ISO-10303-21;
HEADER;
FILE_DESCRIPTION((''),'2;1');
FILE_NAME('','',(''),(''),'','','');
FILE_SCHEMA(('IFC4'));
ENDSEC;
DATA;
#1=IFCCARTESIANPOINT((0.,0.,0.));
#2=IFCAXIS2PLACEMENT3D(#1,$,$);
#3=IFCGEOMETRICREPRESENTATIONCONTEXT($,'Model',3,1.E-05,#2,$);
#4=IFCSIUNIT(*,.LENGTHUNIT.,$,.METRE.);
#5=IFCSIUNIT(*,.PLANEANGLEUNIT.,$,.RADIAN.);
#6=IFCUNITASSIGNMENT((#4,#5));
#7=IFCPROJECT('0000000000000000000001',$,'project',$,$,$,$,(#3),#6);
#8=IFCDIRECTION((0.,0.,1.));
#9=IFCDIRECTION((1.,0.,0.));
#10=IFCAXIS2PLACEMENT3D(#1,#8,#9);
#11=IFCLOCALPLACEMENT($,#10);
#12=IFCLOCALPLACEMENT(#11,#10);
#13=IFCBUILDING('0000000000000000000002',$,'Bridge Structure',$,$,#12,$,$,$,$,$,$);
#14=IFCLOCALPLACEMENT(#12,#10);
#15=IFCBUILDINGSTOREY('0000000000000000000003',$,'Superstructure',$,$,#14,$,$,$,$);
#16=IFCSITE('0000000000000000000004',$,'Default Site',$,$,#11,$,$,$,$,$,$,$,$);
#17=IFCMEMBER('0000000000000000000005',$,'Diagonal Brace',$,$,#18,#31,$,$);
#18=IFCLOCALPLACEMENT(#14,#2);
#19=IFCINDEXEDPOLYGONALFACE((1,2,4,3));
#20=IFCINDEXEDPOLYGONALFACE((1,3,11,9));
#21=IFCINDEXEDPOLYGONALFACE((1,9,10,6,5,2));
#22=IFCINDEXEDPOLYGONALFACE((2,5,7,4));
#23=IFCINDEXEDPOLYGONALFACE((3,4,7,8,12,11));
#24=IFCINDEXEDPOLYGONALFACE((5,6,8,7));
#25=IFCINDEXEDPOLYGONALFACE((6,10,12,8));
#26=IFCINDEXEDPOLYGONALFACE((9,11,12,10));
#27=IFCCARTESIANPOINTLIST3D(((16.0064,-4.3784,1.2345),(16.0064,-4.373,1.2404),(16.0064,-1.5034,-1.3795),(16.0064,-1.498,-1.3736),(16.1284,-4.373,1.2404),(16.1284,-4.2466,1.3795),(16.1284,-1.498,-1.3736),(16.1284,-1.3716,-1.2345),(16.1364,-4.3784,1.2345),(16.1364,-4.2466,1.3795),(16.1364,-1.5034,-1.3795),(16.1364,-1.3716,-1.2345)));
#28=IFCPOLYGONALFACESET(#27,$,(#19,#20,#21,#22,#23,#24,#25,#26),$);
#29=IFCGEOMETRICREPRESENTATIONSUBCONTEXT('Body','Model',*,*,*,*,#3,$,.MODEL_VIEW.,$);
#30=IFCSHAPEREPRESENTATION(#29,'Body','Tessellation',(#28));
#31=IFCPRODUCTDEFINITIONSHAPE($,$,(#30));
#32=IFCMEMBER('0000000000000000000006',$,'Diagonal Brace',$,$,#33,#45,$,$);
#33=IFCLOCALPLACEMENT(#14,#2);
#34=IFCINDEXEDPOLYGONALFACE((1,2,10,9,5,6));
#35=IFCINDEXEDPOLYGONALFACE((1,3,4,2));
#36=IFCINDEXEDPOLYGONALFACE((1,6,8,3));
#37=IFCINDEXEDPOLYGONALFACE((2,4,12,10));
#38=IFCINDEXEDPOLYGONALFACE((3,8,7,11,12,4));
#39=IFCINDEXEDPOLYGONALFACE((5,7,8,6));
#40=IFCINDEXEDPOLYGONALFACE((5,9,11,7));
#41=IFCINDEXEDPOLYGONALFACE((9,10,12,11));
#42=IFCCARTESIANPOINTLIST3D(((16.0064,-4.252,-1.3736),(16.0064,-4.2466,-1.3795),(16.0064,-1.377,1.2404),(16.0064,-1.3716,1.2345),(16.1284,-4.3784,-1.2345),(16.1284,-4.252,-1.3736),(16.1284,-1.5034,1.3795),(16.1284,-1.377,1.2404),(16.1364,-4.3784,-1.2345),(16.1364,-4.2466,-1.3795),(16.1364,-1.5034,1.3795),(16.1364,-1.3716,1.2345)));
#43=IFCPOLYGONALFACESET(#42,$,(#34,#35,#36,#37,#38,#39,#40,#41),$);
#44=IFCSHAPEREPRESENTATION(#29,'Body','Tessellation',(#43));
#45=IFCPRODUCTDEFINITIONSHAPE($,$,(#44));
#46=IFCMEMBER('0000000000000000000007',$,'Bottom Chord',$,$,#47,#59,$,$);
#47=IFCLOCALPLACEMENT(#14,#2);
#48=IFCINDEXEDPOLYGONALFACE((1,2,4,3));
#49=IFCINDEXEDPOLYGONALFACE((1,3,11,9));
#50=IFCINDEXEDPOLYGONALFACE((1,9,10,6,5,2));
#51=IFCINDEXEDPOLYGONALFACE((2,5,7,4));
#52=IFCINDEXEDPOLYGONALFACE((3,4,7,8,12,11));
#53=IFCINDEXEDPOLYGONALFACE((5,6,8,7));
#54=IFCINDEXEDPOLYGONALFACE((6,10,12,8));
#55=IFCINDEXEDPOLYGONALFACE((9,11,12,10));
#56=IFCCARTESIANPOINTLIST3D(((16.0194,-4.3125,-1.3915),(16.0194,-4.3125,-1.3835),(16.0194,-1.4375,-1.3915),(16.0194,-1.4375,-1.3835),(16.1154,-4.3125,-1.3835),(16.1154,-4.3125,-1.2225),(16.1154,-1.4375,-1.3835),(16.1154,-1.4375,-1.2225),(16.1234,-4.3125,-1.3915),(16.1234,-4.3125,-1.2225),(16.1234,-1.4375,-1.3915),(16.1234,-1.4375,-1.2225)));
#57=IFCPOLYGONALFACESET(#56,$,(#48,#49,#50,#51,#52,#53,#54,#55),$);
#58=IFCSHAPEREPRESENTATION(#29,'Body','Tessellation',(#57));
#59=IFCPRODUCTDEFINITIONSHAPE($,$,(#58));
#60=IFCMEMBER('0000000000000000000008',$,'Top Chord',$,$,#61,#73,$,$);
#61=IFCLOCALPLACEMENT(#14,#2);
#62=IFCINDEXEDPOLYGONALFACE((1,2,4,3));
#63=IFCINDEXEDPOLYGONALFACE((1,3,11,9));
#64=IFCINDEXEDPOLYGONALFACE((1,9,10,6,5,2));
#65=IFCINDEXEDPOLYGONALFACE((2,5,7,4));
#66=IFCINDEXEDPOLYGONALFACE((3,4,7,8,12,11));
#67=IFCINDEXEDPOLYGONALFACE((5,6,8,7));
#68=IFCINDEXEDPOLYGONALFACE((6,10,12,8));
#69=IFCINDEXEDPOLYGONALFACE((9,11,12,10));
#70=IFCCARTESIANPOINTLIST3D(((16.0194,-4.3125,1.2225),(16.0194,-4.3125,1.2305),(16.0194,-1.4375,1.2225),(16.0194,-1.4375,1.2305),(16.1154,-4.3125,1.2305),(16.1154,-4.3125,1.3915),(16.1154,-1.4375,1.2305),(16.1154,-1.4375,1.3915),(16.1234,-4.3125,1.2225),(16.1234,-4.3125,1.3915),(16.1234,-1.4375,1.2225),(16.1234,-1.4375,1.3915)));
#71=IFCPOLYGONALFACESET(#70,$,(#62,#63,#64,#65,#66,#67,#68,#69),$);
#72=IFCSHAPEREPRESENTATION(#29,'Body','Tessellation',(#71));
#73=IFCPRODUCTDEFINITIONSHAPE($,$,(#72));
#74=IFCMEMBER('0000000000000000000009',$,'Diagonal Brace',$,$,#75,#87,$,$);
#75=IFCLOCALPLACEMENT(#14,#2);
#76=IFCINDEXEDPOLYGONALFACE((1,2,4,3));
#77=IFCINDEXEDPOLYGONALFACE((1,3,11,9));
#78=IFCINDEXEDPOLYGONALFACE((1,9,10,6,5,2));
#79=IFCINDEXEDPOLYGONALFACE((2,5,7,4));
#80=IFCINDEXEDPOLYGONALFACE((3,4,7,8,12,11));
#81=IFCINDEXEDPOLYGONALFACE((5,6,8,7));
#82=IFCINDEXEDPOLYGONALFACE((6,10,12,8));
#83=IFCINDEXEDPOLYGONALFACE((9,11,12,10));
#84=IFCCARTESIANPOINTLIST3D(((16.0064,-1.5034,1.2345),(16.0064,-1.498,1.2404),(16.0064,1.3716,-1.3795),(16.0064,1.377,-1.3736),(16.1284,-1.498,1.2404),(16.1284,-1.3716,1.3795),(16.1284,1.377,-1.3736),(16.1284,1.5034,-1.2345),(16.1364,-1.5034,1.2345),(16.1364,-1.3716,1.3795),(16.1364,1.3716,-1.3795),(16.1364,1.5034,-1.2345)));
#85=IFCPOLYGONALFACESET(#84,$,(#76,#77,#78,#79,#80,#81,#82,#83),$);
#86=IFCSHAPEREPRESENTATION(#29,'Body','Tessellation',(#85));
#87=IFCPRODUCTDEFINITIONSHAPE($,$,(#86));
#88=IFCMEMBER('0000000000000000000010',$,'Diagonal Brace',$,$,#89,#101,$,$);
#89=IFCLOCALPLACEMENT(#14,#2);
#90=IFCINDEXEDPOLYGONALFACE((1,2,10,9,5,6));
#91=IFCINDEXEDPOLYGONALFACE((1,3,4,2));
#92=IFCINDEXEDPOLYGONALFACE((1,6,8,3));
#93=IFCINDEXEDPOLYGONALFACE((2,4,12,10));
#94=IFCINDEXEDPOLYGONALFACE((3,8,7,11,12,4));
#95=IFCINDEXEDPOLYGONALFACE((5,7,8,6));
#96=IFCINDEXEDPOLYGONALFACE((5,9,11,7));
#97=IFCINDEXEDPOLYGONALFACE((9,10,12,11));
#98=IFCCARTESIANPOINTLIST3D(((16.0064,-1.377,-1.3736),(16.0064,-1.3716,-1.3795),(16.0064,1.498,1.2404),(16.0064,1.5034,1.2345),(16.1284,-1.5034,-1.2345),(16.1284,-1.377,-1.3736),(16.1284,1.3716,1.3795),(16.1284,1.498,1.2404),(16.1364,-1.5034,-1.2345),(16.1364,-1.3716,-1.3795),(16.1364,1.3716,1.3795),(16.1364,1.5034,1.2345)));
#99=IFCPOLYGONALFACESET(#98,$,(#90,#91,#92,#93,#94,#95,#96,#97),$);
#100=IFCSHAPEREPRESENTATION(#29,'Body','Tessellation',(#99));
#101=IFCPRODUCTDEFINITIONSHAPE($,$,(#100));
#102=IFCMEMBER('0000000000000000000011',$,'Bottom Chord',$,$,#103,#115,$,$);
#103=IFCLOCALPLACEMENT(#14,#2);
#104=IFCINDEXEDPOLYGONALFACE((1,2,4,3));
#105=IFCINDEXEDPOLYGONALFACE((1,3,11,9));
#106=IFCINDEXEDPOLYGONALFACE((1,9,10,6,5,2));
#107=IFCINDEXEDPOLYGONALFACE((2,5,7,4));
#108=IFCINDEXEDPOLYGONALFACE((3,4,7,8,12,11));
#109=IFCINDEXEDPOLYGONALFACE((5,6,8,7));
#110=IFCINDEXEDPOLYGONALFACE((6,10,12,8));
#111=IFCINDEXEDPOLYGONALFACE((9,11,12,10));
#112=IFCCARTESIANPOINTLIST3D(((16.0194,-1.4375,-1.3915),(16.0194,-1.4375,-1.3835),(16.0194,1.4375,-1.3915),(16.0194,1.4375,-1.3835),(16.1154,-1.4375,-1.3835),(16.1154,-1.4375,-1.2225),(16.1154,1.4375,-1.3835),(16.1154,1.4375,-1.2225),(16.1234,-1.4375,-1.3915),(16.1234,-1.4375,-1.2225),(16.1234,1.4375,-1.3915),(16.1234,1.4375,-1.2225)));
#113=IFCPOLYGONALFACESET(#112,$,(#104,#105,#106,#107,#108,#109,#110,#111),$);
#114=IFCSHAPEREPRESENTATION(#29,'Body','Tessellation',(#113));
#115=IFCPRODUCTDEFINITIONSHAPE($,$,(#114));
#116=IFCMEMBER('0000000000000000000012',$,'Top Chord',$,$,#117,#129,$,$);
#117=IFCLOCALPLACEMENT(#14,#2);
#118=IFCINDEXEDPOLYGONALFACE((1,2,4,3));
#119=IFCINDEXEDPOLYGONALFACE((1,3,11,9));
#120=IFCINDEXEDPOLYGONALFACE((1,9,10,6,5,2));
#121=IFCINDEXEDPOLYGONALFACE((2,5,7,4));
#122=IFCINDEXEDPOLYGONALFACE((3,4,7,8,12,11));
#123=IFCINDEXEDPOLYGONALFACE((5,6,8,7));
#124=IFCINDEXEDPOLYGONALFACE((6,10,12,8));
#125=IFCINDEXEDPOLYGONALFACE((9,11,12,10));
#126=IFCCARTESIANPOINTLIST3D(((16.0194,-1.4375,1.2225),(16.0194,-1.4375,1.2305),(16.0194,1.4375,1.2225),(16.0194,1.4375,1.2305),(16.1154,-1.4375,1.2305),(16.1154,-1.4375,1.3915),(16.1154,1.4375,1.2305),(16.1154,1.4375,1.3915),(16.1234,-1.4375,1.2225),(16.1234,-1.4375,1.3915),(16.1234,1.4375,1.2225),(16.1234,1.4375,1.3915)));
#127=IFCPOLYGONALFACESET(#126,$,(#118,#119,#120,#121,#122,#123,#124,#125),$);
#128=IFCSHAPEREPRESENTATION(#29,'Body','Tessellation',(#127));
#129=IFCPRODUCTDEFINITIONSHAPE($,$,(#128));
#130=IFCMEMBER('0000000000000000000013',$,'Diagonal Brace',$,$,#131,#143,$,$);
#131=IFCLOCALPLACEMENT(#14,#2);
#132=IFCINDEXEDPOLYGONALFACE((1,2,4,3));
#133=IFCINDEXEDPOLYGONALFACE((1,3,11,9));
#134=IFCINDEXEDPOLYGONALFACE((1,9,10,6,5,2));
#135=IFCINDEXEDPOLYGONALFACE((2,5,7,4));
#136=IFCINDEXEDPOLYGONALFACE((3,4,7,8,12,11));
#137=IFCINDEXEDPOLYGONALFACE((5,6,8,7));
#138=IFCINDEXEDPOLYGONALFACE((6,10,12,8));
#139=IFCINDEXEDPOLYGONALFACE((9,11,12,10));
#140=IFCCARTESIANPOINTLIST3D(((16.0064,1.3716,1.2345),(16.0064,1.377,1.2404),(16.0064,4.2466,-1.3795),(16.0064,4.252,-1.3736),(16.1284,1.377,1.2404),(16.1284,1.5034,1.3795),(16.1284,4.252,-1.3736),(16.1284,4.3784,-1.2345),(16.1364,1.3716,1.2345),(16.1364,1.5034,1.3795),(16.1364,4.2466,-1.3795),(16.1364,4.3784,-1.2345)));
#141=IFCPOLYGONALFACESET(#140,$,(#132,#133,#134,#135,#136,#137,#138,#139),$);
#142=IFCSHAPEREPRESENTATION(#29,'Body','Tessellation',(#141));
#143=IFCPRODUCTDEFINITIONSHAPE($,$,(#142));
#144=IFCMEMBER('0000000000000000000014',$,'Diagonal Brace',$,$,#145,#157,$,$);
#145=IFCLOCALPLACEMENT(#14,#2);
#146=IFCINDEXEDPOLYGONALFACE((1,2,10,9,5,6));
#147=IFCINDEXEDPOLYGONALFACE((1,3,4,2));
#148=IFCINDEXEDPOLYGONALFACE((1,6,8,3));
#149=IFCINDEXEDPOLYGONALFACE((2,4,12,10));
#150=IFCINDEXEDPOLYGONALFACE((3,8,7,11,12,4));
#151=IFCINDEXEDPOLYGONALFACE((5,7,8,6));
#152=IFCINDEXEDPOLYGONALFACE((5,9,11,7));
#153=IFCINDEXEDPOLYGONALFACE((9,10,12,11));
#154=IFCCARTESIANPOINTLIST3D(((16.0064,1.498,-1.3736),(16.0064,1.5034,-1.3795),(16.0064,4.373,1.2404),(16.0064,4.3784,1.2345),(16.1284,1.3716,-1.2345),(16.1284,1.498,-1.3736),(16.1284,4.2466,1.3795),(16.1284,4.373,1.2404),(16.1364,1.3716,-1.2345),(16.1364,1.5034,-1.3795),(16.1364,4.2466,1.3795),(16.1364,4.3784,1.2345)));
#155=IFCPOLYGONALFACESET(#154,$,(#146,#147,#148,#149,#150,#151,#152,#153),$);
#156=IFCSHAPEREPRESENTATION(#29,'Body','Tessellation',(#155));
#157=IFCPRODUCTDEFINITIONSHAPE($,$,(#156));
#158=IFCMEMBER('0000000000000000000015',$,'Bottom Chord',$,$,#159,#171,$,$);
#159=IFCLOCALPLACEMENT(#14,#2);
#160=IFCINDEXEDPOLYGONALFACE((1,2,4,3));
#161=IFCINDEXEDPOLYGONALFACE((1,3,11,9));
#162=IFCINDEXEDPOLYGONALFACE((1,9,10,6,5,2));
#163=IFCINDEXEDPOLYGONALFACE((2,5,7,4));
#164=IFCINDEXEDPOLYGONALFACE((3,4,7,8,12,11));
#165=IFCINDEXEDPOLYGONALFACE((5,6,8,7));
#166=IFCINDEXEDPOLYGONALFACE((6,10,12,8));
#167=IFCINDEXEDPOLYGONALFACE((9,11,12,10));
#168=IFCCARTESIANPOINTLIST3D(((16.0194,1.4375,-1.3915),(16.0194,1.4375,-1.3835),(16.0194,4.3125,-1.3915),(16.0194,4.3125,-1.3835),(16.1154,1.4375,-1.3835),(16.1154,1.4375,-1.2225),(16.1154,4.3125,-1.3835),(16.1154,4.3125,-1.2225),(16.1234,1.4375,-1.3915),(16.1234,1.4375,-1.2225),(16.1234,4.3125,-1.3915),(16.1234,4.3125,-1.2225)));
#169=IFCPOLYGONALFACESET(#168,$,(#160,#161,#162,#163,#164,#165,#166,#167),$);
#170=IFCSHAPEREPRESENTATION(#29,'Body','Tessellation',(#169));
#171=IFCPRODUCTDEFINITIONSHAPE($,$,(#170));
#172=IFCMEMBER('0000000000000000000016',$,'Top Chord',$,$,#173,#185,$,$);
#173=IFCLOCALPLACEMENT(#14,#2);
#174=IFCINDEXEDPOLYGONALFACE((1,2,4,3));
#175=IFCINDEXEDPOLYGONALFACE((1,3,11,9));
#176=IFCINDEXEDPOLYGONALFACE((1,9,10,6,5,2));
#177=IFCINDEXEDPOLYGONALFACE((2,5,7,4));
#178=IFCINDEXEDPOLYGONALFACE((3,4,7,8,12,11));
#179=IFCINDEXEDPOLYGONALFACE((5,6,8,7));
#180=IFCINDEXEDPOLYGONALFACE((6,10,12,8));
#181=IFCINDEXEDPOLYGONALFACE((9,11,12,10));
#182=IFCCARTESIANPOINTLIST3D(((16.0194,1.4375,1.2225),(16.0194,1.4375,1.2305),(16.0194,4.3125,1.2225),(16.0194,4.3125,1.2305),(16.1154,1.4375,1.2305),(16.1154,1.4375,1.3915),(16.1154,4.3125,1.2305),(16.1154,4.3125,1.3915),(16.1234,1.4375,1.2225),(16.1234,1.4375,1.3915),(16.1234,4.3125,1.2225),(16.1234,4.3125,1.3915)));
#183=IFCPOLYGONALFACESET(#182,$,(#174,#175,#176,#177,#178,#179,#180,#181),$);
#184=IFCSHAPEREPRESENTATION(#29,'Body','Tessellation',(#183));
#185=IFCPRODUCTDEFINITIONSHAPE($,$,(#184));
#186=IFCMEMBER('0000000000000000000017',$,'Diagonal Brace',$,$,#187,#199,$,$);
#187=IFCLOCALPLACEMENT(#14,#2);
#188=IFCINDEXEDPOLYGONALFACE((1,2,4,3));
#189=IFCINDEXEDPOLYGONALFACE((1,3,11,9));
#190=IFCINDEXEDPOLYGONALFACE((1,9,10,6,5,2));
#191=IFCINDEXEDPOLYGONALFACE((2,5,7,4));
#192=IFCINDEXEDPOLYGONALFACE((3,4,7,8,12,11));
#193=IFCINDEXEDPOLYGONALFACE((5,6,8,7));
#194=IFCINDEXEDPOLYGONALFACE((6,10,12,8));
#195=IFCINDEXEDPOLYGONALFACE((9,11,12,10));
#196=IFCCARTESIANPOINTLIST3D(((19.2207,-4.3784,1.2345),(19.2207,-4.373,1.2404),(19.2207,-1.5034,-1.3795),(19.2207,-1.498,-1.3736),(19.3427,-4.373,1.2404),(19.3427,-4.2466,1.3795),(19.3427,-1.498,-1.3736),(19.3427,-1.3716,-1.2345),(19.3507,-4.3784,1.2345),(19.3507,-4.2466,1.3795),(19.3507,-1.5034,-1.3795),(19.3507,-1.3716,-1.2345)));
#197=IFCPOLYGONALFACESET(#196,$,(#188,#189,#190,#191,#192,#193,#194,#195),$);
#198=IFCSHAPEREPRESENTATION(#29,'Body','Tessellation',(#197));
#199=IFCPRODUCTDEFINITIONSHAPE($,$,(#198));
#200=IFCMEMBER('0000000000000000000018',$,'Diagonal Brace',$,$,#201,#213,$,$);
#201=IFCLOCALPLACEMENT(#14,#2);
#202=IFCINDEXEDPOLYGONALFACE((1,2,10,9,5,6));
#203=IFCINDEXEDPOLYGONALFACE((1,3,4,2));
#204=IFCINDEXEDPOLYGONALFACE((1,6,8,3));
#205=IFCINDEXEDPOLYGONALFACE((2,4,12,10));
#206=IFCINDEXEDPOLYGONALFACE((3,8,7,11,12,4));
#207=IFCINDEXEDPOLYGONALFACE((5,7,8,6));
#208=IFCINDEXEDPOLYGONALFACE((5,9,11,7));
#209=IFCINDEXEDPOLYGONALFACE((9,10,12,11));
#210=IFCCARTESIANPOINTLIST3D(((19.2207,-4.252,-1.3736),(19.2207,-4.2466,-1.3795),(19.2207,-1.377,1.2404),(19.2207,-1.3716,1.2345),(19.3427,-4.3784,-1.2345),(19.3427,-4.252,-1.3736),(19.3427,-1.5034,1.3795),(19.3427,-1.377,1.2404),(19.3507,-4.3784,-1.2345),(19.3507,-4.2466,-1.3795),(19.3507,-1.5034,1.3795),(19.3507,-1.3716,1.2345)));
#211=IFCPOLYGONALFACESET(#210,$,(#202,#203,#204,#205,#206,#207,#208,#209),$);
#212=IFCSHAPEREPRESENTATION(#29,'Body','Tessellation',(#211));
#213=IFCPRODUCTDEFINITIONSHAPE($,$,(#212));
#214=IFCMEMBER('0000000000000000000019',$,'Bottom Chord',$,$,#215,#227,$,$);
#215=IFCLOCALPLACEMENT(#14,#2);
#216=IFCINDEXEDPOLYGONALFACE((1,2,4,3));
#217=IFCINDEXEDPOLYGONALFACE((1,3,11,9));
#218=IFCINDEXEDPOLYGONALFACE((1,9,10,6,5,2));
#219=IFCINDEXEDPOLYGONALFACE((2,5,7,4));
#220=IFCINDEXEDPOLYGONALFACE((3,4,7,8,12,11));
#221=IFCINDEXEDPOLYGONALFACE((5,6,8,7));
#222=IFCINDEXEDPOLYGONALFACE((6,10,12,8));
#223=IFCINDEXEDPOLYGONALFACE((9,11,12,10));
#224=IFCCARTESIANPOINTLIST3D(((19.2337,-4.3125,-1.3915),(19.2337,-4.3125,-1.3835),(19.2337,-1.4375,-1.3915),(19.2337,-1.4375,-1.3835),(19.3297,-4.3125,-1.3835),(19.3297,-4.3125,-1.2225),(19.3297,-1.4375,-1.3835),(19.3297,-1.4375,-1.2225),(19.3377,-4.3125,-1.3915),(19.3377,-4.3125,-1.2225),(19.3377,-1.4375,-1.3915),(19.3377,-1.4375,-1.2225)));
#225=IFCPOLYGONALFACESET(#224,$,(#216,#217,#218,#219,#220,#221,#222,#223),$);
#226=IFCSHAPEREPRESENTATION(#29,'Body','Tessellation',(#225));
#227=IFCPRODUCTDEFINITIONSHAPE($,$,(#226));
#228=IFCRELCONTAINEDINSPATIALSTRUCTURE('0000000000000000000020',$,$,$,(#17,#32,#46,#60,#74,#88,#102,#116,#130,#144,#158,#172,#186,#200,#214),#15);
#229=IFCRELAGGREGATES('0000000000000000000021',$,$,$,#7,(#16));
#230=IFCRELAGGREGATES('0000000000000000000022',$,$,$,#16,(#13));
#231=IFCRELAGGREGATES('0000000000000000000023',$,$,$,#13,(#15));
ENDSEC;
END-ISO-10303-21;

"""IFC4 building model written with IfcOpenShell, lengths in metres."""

from ifc_helpers import new_model, si_unit, frame, origin, origin_with_axes, origin_2d_with_axis, place, context, subcontext, project, spatial, l_section, extrude, element, save


model = new_model("IFC4")

# Units and contexts
model_context = context("Model", 3, precision=1e-05, world=origin())
body_context = subcontext(model_context, "Body", "Model", "MODEL_VIEW")
ifc_project = project(units=[si_unit("LENGTHUNIT", "METRE"), si_unit("PLANEANGLEUNIT", "RADIAN")], contexts=[model_context])

# Site, building, storey
site_placement = place(None, origin_with_axes())
site = spatial("IfcSite", under=ifc_project, at=site_placement, Name="Default Site")
building_placement = place(site_placement, origin_with_axes())
building = spatial("IfcBuilding", under=site, at=building_placement, Name="Bridge Structure")
storey_placement = place(building_placement, origin_with_axes())
storey = spatial("IfcBuildingStorey", under=building, at=storey_placement, Name="Superstructure")

# Members
for number, where, z_axis, x_axis, name in (
    (1, (16.0714, -4.3125, 1.307), (0.0, 0.739893, -0.672724), (-1.0, 0.0, 0.0), "Diagonal Brace"),
    (2, (16.0714, -4.3125, -1.307), (0.0, 0.739893, 0.672724), (-1.0, 0.0, 0.0), "Diagonal Brace"),
):
    element("IfcMember", number, at=place(storey_placement, frame(where, z_axis=z_axis, x_axis=x_axis)), inside=storey, Name=name, context=body_context, shape_type="SweptSolid", body=[
        extrude(l_section(Depth=0.196, Width=0.13, Thickness=0.008, at=origin_2d_with_axis()), origin_with_axes(), (0.0, 0.0, 1.0), 3.8857),
    ])
for number, where, z_axis, x_axis, name in (
    (3, (16.0714, -4.3125, -1.307), (0.0, 1.0, 0.0), (-1.0, 0.0, 0.0), "Bottom Chord"),
    (4, (16.0714, -4.3125, 1.307), (0.0, 1.0, 0.0), (-1.0, 0.0, 0.0), "Top Chord"),
):
    element("IfcMember", number, at=place(storey_placement, frame(where, z_axis=z_axis, x_axis=x_axis)), inside=storey, Name=name, context=body_context, shape_type="SweptSolid", body=[
        extrude(l_section(Depth=0.169, Width=0.104, Thickness=0.008, at=origin_2d_with_axis()), origin_with_axes(), (0.0, 0.0, 1.0), 2.875),
    ])
for number, where, z_axis, x_axis, name in (
    (5, (16.0714, -1.4375, 1.307), (0.0, 0.739893, -0.672724), (-1.0, 0.0, 0.0), "Diagonal Brace"),
    (6, (16.0714, -1.4375, -1.307), (0.0, 0.739893, 0.672724), (-1.0, 0.0, 0.0), "Diagonal Brace"),
):
    element("IfcMember", number, at=place(storey_placement, frame(where, z_axis=z_axis, x_axis=x_axis)), inside=storey, Name=name, context=body_context, shape_type="SweptSolid", body=[
        extrude(l_section(Depth=0.196, Width=0.13, Thickness=0.008, at=origin_2d_with_axis()), origin_with_axes(), (0.0, 0.0, 1.0), 3.8857),
    ])
for number, where, z_axis, x_axis, name in (
    (7, (16.0714, -1.4375, -1.307), (0.0, 1.0, 0.0), (-1.0, 0.0, 0.0), "Bottom Chord"),
    (8, (16.0714, -1.4375, 1.307), (0.0, 1.0, 0.0), (-1.0, 0.0, 0.0), "Top Chord"),
):
    element("IfcMember", number, at=place(storey_placement, frame(where, z_axis=z_axis, x_axis=x_axis)), inside=storey, Name=name, context=body_context, shape_type="SweptSolid", body=[
        extrude(l_section(Depth=0.169, Width=0.104, Thickness=0.008, at=origin_2d_with_axis()), origin_with_axes(), (0.0, 0.0, 1.0), 2.875),
    ])
for number, where, z_axis, x_axis, name in (
    (9, (16.0714, 1.4375, 1.307), (0.0, 0.739893, -0.672724), (-1.0, 0.0, 0.0), "Diagonal Brace"),
    (10, (16.0714, 1.4375, -1.307), (0.0, 0.739893, 0.672724), (-1.0, 0.0, 0.0), "Diagonal Brace"),
):
    element("IfcMember", number, at=place(storey_placement, frame(where, z_axis=z_axis, x_axis=x_axis)), inside=storey, Name=name, context=body_context, shape_type="SweptSolid", body=[
        extrude(l_section(Depth=0.196, Width=0.13, Thickness=0.008, at=origin_2d_with_axis()), origin_with_axes(), (0.0, 0.0, 1.0), 3.8857),
    ])
for number, where, z_axis, x_axis, name in (
    (11, (16.0714, 1.4375, -1.307), (0.0, 1.0, 0.0), (-1.0, 0.0, 0.0), "Bottom Chord"),
    (12, (16.0714, 1.4375, 1.307), (0.0, 1.0, 0.0), (-1.0, 0.0, 0.0), "Top Chord"),
):
    element("IfcMember", number, at=place(storey_placement, frame(where, z_axis=z_axis, x_axis=x_axis)), inside=storey, Name=name, context=body_context, shape_type="SweptSolid", body=[
        extrude(l_section(Depth=0.169, Width=0.104, Thickness=0.008, at=origin_2d_with_axis()), origin_with_axes(), (0.0, 0.0, 1.0), 2.875),
    ])
for number, where, z_axis, x_axis, name in (
    (13, (19.2857, -4.3125, 1.307), (0.0, 0.739893, -0.672724), (-1.0, 0.0, 0.0), "Diagonal Brace"),
    (14, (19.2857, -4.3125, -1.307), (0.0, 0.739893, 0.672724), (-1.0, 0.0, 0.0), "Diagonal Brace"),
):
    element("IfcMember", number, at=place(storey_placement, frame(where, z_axis=z_axis, x_axis=x_axis)), inside=storey, Name=name, context=body_context, shape_type="SweptSolid", body=[
        extrude(l_section(Depth=0.196, Width=0.13, Thickness=0.008, at=origin_2d_with_axis()), origin_with_axes(), (0.0, 0.0, 1.0), 3.8857),
    ])
for number, where, z_axis, x_axis, name in (
    (15, (19.2857, -4.3125, -1.307), (0.0, 1.0, 0.0), (-1.0, 0.0, 0.0), "Bottom Chord"),
):
    element("IfcMember", number, at=place(storey_placement, frame(where, z_axis=z_axis, x_axis=x_axis)), inside=storey, Name=name, context=body_context, shape_type="SweptSolid", body=[
        extrude(l_section(Depth=0.169, Width=0.104, Thickness=0.008, at=origin_2d_with_axis()), origin_with_axes(), (0.0, 0.0, 1.0), 2.875),
    ])

save(model, "model.ifc")
